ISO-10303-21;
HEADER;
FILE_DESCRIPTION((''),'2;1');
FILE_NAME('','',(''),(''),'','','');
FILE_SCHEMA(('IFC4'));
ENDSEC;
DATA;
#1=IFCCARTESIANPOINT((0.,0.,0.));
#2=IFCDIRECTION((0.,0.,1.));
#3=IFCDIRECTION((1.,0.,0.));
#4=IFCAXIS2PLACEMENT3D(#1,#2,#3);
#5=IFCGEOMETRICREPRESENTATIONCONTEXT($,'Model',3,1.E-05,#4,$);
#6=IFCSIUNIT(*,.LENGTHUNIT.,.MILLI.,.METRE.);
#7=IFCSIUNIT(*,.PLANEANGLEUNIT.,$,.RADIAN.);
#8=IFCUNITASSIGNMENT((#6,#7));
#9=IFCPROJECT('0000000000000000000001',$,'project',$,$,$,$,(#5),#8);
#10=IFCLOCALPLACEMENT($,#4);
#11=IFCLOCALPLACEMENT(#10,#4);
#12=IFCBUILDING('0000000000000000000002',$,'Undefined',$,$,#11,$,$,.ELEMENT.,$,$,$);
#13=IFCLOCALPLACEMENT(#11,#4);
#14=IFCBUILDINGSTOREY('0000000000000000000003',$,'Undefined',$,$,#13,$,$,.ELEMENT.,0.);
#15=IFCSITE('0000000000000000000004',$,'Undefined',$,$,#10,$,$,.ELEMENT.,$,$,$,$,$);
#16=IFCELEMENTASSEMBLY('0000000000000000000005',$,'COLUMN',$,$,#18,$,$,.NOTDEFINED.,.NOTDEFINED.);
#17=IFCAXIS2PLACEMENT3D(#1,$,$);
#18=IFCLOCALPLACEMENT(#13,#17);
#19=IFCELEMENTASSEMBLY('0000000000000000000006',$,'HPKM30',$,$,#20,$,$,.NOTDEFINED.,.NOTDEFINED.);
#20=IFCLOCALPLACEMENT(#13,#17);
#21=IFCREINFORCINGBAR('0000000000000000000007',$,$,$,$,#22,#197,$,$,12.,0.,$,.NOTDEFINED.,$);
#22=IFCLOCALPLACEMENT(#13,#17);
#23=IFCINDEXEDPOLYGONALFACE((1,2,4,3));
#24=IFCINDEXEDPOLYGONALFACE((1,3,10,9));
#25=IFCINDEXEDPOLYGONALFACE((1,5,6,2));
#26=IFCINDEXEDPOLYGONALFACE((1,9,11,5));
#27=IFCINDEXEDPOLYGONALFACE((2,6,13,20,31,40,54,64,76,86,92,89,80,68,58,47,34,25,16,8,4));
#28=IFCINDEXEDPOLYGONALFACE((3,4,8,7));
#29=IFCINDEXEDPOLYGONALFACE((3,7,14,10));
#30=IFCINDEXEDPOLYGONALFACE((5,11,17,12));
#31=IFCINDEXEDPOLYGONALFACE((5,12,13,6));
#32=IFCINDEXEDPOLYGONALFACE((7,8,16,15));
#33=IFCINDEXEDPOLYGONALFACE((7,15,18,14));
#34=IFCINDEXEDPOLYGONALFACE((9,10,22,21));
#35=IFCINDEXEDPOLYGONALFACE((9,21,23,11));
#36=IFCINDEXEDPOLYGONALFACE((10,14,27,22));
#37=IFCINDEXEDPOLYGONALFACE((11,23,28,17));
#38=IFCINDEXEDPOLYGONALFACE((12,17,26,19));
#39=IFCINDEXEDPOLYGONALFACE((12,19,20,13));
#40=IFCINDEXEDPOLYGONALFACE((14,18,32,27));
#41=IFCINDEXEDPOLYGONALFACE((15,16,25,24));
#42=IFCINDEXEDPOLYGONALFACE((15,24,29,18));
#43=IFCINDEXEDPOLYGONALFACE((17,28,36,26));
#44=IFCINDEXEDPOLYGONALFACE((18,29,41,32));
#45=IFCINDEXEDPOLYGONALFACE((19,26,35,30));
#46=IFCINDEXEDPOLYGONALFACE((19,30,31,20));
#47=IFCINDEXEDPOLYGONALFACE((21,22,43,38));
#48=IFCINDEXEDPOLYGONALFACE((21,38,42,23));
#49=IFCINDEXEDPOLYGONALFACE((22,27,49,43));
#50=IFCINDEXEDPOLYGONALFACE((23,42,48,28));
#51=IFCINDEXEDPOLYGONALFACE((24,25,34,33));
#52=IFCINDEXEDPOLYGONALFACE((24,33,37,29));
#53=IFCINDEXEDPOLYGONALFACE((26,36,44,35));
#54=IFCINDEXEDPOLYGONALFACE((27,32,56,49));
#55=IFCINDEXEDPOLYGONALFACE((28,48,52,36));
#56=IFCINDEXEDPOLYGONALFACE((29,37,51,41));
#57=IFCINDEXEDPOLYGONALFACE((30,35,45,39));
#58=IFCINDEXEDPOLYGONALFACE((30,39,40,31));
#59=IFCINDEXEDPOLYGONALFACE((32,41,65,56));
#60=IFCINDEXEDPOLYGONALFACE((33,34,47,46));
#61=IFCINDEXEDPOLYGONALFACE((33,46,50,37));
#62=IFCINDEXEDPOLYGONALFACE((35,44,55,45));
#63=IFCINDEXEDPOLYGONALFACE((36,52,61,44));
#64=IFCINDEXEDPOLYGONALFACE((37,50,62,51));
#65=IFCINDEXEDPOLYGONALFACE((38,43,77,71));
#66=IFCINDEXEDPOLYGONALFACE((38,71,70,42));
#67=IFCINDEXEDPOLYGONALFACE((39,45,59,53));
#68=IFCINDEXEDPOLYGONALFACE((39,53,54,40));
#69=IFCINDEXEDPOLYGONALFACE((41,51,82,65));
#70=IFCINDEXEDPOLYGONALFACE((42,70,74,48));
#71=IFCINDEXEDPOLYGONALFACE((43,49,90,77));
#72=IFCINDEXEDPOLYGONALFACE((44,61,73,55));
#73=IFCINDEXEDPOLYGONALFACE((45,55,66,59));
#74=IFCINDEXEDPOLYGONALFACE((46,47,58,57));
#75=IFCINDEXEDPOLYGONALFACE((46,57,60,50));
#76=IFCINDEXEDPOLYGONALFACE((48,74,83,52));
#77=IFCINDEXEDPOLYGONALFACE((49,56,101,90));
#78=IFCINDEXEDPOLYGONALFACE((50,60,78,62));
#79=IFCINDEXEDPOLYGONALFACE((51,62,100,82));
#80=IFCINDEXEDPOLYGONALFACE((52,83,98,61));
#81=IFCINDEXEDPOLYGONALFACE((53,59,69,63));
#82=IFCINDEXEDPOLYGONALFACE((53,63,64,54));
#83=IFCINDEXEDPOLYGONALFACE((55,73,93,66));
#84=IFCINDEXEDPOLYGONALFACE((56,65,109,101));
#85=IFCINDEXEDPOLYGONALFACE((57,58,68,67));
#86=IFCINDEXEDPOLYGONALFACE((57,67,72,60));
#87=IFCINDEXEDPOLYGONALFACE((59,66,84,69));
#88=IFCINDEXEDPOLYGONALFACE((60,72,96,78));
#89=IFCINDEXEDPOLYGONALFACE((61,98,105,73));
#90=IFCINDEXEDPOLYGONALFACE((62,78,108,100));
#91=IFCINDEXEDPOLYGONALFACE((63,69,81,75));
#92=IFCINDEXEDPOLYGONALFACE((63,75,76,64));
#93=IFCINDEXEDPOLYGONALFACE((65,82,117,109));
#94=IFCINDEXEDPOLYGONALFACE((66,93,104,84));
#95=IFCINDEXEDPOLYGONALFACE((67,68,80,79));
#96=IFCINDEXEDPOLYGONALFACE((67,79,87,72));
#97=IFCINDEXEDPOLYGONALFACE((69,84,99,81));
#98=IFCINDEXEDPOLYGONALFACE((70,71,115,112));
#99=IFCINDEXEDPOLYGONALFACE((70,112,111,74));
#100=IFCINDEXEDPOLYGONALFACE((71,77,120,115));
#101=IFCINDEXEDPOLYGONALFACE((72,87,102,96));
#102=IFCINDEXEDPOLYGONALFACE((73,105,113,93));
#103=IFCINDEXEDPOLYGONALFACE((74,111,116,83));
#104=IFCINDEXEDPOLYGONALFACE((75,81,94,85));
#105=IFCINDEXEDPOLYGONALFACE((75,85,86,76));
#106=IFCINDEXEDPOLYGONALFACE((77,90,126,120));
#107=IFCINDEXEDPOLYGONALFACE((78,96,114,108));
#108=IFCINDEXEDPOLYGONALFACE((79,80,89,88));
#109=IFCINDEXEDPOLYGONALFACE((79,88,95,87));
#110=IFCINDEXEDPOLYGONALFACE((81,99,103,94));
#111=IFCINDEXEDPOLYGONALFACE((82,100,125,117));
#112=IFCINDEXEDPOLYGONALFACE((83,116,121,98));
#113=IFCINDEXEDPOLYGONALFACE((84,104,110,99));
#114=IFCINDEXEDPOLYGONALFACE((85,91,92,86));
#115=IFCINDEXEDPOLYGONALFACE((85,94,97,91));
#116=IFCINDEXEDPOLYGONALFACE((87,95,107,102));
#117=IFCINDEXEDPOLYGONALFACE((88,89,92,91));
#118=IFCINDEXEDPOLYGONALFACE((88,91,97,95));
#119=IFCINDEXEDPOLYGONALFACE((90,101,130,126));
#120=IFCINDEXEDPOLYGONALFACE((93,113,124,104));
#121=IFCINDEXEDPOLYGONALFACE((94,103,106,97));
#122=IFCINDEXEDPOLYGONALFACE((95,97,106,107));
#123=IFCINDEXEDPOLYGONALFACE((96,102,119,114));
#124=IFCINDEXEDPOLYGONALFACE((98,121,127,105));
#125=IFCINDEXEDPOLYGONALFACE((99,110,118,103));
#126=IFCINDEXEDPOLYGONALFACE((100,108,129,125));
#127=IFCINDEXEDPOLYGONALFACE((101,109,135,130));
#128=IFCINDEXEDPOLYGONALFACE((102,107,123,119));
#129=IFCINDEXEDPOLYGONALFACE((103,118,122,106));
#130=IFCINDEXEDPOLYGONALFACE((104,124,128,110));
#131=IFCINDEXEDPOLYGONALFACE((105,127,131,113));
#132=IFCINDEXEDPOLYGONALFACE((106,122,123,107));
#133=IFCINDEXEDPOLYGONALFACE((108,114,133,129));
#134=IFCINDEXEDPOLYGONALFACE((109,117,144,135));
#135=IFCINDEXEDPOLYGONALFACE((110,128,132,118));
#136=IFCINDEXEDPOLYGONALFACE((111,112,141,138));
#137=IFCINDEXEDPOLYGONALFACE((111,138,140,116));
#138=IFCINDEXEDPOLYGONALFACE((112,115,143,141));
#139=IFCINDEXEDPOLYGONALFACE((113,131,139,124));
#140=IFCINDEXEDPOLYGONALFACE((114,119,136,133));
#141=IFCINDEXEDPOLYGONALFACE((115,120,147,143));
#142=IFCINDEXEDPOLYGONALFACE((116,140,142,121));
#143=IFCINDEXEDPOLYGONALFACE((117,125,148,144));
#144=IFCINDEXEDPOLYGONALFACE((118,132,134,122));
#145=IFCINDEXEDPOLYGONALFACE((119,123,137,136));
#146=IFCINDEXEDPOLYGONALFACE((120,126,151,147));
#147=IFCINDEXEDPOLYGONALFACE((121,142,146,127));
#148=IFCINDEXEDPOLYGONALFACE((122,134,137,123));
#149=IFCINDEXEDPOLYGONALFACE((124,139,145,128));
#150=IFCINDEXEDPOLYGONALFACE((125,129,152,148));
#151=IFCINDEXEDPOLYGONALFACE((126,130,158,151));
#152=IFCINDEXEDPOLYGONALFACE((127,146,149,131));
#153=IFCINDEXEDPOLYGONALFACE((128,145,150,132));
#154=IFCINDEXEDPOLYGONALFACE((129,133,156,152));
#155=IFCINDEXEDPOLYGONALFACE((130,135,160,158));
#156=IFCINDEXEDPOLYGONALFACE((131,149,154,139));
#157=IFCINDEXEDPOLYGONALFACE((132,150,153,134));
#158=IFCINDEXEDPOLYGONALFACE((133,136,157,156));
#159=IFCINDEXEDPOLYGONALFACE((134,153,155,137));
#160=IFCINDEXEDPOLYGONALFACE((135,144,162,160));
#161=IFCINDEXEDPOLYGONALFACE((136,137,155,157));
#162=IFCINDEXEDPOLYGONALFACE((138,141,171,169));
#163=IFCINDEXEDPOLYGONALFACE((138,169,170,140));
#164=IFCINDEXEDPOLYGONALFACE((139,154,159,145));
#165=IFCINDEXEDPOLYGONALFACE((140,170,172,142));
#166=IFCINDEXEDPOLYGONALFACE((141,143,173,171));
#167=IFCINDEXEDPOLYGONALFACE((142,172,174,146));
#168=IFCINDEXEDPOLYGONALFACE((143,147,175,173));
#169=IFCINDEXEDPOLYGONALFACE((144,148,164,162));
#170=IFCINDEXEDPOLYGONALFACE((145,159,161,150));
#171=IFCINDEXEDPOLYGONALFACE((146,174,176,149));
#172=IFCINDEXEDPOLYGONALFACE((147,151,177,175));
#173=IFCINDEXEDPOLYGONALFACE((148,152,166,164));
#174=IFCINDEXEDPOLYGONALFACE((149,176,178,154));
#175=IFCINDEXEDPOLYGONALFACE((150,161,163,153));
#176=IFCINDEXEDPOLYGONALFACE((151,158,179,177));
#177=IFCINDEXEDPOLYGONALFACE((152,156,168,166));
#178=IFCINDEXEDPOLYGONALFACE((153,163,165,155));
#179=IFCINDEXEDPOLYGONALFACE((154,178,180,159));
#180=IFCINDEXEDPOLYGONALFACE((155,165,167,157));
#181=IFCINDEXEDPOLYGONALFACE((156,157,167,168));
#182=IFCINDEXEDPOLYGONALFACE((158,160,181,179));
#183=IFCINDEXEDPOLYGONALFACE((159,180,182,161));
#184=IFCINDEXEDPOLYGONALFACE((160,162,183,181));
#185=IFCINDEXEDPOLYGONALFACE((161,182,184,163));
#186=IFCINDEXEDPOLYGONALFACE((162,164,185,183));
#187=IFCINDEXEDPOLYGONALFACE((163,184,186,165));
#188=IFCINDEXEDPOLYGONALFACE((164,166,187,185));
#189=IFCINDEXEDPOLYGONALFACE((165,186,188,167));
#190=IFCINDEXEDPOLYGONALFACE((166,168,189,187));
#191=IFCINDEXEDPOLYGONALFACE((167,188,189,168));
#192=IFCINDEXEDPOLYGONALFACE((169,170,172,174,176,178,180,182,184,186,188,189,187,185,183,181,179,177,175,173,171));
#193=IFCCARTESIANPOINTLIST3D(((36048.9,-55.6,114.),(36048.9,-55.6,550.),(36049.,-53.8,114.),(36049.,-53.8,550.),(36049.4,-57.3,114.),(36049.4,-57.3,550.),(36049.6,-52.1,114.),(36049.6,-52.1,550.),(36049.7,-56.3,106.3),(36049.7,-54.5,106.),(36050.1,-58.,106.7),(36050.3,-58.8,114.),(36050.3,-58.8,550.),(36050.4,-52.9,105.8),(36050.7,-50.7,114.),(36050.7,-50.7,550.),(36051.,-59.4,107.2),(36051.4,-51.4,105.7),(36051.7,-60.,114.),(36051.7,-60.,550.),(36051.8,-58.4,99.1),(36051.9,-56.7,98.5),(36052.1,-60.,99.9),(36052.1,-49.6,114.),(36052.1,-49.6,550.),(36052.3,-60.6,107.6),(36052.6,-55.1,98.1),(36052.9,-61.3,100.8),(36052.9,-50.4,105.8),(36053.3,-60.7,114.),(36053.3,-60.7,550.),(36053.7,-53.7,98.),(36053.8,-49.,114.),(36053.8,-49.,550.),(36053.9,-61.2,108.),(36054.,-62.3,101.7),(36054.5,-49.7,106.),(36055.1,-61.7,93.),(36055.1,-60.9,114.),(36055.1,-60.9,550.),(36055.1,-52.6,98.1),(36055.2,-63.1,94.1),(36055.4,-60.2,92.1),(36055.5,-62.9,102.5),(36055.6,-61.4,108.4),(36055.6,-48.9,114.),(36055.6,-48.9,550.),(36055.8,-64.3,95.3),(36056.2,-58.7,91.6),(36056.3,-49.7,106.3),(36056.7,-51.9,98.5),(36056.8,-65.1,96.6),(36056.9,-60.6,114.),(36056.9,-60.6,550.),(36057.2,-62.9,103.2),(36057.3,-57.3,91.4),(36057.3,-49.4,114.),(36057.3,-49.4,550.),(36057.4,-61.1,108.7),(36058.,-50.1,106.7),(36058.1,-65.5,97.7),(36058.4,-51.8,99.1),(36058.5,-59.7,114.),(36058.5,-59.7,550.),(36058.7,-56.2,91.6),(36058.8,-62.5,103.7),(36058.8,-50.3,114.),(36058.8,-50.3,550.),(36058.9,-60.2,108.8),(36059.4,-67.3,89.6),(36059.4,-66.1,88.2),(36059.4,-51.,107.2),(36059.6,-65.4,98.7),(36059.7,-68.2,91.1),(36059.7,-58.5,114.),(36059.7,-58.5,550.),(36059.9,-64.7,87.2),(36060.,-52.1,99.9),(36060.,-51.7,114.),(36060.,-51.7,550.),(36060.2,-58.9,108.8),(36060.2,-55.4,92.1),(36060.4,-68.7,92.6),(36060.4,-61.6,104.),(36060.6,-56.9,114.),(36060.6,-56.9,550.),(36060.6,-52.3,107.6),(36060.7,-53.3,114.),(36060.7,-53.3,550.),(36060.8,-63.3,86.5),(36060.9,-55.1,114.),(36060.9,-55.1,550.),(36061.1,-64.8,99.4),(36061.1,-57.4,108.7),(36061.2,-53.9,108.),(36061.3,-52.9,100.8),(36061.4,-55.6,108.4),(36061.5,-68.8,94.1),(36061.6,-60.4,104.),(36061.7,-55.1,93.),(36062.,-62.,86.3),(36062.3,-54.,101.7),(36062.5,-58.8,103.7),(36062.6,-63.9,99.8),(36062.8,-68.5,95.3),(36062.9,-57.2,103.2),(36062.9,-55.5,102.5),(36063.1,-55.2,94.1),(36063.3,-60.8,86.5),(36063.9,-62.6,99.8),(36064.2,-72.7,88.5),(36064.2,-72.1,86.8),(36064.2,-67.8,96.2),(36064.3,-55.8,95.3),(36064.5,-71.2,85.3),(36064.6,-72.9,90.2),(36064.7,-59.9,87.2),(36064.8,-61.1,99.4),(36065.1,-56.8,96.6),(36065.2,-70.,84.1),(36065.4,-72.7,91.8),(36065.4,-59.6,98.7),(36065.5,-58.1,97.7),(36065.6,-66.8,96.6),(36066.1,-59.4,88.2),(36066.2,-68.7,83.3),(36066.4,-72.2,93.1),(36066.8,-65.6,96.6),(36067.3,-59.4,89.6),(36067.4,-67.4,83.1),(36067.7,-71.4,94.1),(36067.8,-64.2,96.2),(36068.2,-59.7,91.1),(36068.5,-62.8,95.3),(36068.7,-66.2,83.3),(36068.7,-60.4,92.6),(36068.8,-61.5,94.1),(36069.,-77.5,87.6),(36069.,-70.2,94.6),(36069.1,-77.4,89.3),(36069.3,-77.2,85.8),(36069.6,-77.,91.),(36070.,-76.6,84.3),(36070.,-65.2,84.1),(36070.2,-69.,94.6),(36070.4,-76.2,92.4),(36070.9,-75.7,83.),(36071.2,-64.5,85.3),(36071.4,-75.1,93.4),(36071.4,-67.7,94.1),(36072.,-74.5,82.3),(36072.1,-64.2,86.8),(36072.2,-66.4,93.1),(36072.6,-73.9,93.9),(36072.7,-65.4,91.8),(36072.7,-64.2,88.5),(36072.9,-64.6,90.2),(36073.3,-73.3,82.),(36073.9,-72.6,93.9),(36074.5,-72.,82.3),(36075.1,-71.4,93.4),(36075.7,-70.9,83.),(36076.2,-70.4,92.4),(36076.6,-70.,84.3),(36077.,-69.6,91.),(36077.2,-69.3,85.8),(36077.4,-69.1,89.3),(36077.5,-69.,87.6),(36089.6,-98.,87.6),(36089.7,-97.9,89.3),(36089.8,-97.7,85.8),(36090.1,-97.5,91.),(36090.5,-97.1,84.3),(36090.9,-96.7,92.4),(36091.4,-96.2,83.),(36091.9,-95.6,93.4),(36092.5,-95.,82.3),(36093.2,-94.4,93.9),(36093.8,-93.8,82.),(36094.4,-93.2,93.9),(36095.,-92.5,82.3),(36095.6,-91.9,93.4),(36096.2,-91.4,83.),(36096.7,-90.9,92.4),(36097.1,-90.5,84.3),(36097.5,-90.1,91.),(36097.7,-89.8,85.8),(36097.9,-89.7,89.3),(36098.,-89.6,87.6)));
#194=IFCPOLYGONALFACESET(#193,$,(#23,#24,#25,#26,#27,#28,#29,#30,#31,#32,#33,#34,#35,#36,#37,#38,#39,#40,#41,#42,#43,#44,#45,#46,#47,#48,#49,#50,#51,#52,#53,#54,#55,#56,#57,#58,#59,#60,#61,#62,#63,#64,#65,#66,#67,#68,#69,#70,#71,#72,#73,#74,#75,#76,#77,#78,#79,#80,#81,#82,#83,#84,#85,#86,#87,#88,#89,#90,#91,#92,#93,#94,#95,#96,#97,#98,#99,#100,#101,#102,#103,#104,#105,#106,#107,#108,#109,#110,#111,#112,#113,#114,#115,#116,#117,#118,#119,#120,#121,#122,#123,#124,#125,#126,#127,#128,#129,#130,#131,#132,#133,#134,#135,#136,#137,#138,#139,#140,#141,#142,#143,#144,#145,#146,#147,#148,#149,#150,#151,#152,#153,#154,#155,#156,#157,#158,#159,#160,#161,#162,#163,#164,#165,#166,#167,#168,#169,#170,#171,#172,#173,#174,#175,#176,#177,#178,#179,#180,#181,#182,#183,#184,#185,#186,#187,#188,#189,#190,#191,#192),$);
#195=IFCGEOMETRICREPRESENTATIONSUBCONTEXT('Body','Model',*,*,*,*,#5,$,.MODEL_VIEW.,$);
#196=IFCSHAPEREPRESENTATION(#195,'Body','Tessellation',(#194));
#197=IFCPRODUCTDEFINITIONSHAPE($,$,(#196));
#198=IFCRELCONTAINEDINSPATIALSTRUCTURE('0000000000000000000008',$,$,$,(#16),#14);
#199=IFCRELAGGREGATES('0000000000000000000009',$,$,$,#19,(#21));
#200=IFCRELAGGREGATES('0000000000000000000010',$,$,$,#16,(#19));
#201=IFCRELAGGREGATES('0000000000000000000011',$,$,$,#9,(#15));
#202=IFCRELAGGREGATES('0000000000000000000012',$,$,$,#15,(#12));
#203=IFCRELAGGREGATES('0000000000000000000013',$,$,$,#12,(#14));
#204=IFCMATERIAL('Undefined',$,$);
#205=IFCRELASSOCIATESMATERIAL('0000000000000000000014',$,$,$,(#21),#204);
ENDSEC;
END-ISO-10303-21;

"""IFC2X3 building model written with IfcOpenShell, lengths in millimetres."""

from ifc_helpers import new_model, entity, si_unit, frame, origin_with_axes, place, context, subcontext, project, spatial, source, transform, mapped, material, element, aggregate, save


model = new_model("IFC2X3")

# Units and contexts
model_context = context("Model", 3, precision=1e-05, world=origin_with_axes())
body_context = subcontext(model_context, "Body", "Model", "MODEL_VIEW")
ifc_project = project(units=[si_unit("LENGTHUNIT", "METRE", prefix="MILLI"), si_unit("PLANEANGLEUNIT", "RADIAN")], contexts=[model_context])

# Site, building, storey
site_placement = place(None, origin_with_axes())
site = spatial("IfcSite", under=ifc_project, at=site_placement, Name="Undefined", CompositionType="ELEMENT")
building_placement = place(site_placement, origin_with_axes())
building = spatial("IfcBuilding", under=site, at=building_placement, Name="Undefined", CompositionType="ELEMENT")
storey_placement = place(building_placement, origin_with_axes())
storey = spatial("IfcBuildingStorey", under=building, at=storey_placement, Name="Undefined", CompositionType="ELEMENT", Elevation=0.0)

# Element assemblies
assembly_1_placement = place(storey_placement, origin_with_axes())
assembly_1 = element("IfcElementAssembly", 1, at=assembly_1_placement, inside=storey, Name="COLUMN", AssemblyPlace="NOTDEFINED", PredefinedType="NOTDEFINED")
assembly_2_placement = place(assembly_1_placement, origin_with_axes())
assembly_2 = element("IfcElementAssembly", 2, at=assembly_2_placement, Name="HPKM30", AssemblyPlace="NOTDEFINED", PredefinedType="NOTDEFINED")

# Shared definitions
ifc_material_1 = material(Name="Undefined")

# Reinforcing bar
shared_shape_1 = source(origin_with_axes(), body_context, "Body", "AdvancedSweptSolid", [
    entity("IfcSweptDiskSolid", entity("IfcCompositeCurve", [entity("IfcCompositeCurveSegment", "CONTINUOUS", True, entity("IfcTrimmedCurve", entity("IfcLine", entity("IfcCartesianPoint", [0.0, 0.0, 0.0]), entity("IfcVector", entity("IfcDirection", [0.0, 0.0, -1.0]), 1.0)), [entity("IfcParameterValue", 0.0)], [entity("IfcParameterValue", 29.0)], True, "PARAMETER")), entity("IfcCompositeCurveSegment", "CONTINUOUS", True, entity("IfcTrimmedCurve", entity("IfcCircle", entity("IfcAxis2Placement3D", entity("IfcCartesianPoint", [26.0, 0.0, -29.0]), entity("IfcDirection", [0.0, -1.0, 0.0]), entity("IfcDirection", [-1.0, 0.0, 0.0])), 26.0), [entity("IfcParameterValue", 0.0)], [entity("IfcParameterValue", 1.570796)], True, "PARAMETER")), entity("IfcCompositeCurveSegment", "DISCONTINUOUS", True, entity("IfcTrimmedCurve", entity("IfcLine", entity("IfcCartesianPoint", [26.0, 0.0, -55.0]), entity("IfcVector", entity("IfcDirection", [1.0, 0.0, 0.0]), 1.0)), [entity("IfcParameterValue", 0.0)], [entity("IfcParameterValue", 436.0)], True, "PARAMETER"))], False), 6.0, None, 0.0, 466.6),
])
reinforcing_bar_1_placement = place(assembly_2_placement, frame((36054.9, -54.9, 88.0), z_axis=(0.707107, -0.707107, 0.0), x_axis=(0.0, 0.0, 1.0)))
reinforcing_bar_1 = element("IfcReinforcingBar", 3, at=reinforcing_bar_1_placement, material=ifc_material_1, BarRole="NOTDEFINED", CrossSectionArea=0.0, NominalDiameter=12.0, context=body_context, shape_type="MappedRepresentation", body=[
    mapped(shared_shape_1, transform((0.0, 0.0, 55.0))),
])
aggregate(assembly_2, [reinforcing_bar_1])
aggregate(assembly_1, [assembly_2])

save(model, "model.ifc")
